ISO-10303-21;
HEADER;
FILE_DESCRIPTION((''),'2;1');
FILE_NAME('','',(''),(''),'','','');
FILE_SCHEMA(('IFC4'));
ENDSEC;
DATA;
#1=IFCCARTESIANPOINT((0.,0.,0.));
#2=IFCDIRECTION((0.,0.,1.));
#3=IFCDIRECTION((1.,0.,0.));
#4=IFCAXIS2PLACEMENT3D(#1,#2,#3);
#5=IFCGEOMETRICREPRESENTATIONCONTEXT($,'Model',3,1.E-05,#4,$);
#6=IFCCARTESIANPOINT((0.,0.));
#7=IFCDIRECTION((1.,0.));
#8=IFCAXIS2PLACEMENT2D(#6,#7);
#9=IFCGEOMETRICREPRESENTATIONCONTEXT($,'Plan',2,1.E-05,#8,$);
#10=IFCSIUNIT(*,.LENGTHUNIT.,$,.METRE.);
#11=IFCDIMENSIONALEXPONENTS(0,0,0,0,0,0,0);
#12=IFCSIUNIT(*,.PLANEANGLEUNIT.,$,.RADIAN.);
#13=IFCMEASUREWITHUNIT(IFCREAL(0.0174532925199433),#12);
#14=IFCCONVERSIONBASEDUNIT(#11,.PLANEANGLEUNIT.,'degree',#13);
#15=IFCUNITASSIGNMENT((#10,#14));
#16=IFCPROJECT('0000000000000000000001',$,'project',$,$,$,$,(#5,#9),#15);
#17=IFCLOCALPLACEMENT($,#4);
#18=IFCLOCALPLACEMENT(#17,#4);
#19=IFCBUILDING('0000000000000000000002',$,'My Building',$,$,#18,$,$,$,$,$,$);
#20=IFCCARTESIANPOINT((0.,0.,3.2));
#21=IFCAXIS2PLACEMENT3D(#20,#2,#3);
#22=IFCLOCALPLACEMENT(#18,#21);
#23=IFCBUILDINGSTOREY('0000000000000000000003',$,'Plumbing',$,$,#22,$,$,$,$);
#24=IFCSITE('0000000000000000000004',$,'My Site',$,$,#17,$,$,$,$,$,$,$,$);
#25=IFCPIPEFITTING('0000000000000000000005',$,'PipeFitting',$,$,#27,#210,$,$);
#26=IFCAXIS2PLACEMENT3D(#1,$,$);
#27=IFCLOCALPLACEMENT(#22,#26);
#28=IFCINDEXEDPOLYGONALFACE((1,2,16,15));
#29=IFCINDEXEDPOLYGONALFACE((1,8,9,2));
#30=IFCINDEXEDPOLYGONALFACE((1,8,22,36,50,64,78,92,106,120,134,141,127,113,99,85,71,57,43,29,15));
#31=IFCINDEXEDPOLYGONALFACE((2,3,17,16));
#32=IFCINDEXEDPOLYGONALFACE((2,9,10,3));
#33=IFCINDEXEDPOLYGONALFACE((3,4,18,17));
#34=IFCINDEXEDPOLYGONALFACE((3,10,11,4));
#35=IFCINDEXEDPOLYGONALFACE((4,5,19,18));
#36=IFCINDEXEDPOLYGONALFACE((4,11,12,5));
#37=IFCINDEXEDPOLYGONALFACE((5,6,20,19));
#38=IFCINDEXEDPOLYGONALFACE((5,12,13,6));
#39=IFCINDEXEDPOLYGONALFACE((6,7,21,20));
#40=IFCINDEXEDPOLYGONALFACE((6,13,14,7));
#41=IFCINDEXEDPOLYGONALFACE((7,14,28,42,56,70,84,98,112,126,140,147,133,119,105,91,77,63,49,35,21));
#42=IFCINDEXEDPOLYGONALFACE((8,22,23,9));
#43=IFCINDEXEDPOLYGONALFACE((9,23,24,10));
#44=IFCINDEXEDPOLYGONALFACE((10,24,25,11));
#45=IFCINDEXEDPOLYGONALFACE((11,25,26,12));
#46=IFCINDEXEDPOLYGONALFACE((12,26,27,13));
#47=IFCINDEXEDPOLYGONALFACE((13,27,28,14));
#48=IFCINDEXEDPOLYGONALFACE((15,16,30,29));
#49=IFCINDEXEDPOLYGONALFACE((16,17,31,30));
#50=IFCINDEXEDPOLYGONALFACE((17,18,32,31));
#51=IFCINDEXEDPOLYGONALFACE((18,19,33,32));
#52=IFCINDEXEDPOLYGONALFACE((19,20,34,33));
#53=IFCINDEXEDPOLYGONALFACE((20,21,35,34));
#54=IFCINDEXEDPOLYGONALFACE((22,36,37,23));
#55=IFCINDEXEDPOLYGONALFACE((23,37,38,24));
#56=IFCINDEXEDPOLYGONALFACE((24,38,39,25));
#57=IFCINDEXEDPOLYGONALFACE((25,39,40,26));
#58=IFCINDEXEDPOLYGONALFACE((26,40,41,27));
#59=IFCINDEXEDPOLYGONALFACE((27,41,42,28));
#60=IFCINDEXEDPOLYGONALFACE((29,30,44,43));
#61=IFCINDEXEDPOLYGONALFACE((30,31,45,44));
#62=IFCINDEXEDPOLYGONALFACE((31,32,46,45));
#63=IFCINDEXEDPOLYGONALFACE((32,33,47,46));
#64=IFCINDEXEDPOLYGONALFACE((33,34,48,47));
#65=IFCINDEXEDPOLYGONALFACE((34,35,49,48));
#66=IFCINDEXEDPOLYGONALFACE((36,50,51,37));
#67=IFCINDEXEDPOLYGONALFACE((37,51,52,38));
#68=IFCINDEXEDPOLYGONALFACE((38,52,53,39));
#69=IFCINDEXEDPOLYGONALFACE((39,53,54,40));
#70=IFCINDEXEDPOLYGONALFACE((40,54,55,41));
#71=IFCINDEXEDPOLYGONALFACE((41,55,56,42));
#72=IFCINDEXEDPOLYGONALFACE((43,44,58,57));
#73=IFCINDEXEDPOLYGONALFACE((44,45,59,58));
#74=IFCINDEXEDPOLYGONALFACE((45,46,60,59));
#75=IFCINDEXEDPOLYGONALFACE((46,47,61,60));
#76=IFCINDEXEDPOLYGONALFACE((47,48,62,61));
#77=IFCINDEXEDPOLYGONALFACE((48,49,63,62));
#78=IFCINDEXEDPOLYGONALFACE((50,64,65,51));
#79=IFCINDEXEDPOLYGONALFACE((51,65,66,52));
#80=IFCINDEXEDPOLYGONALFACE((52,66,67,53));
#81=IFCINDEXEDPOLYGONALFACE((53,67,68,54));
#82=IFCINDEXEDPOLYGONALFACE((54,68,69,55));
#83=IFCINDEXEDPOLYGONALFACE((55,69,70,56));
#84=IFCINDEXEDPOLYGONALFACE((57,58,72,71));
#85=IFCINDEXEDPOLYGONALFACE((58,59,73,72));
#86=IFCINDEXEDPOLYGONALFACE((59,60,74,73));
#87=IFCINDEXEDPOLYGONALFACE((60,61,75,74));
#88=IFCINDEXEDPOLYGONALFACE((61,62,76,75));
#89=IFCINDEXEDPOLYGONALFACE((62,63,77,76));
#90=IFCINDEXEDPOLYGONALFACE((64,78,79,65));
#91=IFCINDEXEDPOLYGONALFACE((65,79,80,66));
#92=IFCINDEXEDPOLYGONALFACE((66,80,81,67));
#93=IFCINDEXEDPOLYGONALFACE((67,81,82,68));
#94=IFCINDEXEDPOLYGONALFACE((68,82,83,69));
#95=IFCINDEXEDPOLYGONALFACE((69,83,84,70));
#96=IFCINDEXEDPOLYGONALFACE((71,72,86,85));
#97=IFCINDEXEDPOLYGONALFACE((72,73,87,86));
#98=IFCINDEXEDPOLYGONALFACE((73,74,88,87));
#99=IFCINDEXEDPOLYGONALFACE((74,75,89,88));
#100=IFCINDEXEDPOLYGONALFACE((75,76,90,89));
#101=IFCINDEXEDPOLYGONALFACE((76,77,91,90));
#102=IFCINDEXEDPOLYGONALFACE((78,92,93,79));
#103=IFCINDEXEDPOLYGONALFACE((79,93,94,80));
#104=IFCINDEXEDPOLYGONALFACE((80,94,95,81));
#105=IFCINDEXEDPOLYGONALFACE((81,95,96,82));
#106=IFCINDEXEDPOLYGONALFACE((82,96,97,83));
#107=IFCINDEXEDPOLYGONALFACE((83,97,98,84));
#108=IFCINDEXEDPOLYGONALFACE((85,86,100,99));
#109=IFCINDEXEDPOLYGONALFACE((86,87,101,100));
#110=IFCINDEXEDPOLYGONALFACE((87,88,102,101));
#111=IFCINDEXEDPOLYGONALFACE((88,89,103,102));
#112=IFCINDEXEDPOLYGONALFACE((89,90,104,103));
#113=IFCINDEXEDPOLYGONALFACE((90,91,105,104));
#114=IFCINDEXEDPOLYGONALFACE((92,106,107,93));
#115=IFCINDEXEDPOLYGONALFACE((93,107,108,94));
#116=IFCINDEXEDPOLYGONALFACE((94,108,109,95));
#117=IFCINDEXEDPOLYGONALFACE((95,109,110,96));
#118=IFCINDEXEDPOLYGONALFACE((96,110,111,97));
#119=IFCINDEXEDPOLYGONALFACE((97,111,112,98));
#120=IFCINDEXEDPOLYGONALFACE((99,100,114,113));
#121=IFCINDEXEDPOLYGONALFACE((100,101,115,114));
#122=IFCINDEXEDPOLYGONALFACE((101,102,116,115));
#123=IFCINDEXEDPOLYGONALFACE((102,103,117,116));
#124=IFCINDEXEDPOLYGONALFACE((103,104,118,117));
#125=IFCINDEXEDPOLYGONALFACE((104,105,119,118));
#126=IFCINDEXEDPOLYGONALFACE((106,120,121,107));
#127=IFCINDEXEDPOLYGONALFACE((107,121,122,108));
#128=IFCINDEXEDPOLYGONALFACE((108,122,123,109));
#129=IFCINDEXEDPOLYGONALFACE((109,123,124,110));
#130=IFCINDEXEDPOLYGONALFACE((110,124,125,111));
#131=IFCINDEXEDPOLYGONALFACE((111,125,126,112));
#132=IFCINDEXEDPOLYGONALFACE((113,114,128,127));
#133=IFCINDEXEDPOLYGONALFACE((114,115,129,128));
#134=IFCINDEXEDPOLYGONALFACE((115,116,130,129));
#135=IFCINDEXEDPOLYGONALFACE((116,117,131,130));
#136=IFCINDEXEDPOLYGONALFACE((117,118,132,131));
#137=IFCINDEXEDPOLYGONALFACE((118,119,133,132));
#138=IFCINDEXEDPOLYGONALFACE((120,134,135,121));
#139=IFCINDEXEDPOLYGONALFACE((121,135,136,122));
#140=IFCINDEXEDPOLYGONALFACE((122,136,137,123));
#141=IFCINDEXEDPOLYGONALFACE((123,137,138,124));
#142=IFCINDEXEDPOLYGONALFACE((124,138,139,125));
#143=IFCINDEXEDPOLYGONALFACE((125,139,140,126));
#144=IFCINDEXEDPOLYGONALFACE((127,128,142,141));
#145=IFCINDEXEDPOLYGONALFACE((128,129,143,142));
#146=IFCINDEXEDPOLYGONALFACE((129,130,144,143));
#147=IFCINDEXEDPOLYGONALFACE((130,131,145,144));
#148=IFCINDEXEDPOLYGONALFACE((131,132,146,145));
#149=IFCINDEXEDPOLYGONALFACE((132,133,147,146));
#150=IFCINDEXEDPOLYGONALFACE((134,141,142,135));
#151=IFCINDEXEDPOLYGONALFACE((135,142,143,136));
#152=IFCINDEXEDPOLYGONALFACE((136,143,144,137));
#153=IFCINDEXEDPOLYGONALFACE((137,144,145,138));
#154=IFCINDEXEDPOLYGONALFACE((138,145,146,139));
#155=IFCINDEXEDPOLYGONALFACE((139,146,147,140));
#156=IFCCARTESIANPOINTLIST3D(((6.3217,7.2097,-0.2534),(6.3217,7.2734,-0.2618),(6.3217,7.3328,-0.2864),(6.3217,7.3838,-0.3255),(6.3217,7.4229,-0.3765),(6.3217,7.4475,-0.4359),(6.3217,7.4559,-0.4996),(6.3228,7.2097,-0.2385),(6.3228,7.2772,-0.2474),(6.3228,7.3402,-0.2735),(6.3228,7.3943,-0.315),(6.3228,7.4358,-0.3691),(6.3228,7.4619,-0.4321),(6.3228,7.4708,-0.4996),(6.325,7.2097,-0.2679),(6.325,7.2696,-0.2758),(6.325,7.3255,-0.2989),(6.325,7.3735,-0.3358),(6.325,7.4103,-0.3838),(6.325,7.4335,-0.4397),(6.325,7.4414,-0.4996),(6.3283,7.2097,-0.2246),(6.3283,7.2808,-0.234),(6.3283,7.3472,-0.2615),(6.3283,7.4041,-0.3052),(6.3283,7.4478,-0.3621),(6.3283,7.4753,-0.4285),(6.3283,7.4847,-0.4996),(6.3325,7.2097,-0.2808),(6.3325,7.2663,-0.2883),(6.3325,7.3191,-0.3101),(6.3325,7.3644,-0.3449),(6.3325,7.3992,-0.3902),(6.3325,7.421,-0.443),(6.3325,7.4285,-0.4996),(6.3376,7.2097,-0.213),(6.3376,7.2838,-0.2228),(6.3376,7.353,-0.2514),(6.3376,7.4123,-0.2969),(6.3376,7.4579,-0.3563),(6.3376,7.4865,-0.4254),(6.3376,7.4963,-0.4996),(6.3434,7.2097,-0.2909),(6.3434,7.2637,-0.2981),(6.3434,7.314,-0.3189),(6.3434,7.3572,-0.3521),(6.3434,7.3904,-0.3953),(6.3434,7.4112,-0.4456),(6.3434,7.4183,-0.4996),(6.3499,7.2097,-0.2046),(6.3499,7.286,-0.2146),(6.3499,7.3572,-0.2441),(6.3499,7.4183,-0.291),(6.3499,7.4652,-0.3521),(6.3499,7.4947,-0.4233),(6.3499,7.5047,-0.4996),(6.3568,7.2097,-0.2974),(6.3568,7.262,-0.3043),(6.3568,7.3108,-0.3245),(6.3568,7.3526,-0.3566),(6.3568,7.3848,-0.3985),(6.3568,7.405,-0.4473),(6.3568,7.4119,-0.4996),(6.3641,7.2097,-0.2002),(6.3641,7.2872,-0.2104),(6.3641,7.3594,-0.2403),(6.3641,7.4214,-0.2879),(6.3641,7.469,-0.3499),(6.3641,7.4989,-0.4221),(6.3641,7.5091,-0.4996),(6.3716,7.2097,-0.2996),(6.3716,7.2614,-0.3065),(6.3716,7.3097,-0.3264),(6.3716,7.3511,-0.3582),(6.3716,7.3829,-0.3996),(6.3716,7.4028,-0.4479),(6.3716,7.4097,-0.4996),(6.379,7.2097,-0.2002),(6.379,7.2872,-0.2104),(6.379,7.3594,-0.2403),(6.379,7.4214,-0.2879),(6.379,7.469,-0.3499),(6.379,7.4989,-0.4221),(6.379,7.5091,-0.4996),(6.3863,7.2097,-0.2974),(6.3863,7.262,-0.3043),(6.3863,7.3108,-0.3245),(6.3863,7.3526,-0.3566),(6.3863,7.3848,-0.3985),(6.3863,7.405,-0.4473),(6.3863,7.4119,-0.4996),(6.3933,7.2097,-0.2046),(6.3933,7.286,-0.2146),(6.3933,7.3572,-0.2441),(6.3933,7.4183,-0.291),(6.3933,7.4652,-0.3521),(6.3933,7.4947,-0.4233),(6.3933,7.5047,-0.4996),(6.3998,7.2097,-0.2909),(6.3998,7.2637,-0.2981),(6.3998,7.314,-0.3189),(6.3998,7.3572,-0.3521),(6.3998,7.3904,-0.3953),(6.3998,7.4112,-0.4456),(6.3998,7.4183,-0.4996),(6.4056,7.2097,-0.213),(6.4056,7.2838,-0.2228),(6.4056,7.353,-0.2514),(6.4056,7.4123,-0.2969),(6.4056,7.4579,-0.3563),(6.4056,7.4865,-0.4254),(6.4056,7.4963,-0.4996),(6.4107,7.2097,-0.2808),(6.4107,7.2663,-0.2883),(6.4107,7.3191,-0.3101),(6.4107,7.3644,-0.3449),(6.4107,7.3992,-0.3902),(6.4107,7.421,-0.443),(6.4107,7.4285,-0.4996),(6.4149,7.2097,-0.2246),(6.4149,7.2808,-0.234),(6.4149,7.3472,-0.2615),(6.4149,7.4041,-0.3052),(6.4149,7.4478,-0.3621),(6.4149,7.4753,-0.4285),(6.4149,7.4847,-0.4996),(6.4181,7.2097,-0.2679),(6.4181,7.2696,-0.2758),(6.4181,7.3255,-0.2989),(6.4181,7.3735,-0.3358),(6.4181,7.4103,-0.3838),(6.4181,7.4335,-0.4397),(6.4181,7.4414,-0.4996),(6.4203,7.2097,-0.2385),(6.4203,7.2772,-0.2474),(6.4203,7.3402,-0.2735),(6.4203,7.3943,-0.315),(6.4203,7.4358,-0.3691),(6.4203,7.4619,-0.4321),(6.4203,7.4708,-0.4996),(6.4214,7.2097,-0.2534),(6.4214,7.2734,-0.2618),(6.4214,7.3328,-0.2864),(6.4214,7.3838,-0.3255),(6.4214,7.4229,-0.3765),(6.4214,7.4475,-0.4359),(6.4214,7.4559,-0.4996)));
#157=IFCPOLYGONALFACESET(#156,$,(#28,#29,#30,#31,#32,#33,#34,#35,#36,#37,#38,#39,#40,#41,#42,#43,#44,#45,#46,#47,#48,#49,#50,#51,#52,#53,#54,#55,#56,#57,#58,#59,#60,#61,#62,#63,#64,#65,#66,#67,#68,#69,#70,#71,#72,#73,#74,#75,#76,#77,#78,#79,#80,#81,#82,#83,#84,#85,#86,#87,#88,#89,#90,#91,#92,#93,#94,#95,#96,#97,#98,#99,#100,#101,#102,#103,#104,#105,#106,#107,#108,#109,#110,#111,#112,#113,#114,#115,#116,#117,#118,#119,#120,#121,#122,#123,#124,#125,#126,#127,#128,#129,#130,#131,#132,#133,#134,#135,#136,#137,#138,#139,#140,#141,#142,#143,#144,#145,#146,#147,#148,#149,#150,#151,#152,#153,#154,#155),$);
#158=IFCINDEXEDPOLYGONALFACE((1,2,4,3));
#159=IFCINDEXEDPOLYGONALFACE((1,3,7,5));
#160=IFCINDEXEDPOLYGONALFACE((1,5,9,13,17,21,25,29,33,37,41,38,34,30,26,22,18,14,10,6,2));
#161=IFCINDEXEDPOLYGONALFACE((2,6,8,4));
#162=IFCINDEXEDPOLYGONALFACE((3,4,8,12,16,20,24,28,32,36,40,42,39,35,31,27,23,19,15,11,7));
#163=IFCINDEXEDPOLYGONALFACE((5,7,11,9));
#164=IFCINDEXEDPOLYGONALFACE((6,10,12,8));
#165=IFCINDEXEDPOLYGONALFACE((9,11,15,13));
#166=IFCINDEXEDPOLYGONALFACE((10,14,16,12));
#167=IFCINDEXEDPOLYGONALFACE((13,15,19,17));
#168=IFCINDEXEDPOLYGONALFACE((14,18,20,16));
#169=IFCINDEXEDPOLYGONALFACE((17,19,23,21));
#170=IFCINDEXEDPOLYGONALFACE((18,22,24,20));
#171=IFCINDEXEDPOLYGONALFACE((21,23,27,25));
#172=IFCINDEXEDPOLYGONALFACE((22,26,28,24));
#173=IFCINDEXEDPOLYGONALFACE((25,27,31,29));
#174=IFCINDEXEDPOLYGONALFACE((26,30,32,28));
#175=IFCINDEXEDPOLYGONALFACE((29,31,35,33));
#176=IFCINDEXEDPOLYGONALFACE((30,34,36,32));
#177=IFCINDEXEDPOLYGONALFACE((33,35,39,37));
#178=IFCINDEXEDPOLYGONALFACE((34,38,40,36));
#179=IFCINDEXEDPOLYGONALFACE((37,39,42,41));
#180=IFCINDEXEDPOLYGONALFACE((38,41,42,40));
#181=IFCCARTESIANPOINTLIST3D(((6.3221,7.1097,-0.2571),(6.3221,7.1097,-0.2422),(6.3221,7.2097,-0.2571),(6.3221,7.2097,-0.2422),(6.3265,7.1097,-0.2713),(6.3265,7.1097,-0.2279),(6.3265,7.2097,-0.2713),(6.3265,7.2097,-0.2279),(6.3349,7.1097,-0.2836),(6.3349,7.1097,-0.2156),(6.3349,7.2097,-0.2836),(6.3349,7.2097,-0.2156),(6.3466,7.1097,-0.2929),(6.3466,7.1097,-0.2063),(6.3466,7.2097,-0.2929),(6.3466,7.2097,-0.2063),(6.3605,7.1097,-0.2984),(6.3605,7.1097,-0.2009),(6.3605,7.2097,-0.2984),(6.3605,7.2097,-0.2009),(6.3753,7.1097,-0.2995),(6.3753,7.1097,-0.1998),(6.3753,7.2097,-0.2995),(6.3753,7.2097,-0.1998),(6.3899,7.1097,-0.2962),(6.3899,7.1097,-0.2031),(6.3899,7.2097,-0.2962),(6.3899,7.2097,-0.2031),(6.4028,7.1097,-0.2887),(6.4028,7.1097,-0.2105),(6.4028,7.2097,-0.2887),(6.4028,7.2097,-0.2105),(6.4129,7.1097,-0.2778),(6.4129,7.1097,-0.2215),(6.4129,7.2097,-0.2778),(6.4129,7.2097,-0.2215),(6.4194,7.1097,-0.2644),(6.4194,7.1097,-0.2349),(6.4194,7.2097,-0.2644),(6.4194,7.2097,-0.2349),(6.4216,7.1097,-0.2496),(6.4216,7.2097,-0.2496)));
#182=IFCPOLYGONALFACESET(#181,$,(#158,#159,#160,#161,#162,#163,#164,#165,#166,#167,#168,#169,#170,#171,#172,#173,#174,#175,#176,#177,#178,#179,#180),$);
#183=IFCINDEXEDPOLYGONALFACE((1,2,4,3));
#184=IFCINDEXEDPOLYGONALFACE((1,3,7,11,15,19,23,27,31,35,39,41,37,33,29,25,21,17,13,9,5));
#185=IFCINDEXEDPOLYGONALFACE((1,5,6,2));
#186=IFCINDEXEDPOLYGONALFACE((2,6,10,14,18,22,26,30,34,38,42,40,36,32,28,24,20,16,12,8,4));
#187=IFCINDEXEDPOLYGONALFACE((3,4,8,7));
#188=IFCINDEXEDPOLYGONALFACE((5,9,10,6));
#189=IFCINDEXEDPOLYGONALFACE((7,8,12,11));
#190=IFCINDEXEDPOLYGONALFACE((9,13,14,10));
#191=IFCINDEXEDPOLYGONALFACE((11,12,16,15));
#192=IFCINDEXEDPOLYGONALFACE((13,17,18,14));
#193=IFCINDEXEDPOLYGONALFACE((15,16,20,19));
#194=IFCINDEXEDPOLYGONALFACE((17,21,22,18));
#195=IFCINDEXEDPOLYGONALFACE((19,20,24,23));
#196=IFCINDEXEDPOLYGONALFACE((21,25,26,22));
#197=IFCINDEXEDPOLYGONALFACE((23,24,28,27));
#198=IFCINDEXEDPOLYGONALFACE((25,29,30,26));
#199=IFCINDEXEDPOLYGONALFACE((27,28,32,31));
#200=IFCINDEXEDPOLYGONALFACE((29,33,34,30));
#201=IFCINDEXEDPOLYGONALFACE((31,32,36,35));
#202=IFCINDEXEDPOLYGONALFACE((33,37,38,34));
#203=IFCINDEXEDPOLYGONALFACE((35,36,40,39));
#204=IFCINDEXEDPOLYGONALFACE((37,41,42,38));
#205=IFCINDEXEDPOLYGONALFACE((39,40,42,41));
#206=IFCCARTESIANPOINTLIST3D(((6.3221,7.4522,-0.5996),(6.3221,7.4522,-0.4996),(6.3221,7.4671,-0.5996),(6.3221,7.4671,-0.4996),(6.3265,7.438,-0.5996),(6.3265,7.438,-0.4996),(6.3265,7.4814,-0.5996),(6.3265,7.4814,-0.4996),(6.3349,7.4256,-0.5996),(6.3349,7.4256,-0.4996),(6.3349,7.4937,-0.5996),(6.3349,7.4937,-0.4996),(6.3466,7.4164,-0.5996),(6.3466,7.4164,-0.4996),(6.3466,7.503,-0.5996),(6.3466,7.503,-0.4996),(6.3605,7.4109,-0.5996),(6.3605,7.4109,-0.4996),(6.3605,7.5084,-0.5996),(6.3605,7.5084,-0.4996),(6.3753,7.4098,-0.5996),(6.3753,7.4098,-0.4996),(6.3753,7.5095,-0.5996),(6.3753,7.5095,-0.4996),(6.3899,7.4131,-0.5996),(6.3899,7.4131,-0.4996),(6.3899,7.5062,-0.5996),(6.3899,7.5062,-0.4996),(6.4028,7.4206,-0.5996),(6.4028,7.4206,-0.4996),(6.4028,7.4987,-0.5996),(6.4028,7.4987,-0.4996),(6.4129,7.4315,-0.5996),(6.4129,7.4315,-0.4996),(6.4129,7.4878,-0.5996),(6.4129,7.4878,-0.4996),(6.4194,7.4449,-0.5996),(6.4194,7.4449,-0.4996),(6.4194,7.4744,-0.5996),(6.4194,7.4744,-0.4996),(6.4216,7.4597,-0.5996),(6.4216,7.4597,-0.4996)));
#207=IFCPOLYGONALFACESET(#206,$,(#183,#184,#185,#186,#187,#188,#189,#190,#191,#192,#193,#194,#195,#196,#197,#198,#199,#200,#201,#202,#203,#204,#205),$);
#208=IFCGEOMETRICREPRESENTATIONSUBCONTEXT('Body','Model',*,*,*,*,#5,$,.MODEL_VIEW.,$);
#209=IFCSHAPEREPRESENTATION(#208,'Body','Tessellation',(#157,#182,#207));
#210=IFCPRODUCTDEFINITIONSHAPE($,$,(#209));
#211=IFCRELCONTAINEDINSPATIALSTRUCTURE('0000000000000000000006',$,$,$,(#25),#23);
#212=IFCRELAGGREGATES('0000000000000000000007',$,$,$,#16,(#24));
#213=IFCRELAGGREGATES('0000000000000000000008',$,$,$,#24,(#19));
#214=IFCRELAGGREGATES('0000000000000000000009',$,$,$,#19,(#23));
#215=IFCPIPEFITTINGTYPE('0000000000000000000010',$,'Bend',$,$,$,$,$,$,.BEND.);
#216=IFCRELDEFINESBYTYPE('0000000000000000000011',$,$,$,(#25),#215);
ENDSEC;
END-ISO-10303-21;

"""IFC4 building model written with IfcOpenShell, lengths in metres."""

from ifc_helpers import new_model, entity, si_unit, converted_unit, frame, origin_with_axes, origin_2d_with_axis, place, context, subcontext, project, spatial, circle, extrude, source, transform, mapped, type_object, type_shapes, element, save


model = new_model("IFC4")

# Units and contexts
model_context = context("Model", 3, precision=1e-05, world=origin_with_axes())
plan_context = context("Plan", 2, precision=1e-05, world=origin_2d_with_axis())
body_context = subcontext(model_context, "Body", "Model", "MODEL_VIEW")
ifc_project = project(units=[si_unit("LENGTHUNIT", "METRE"), converted_unit("PLANEANGLEUNIT", "degree", entity("IfcReal", 0.0174532925199433), si_unit("PLANEANGLEUNIT", "RADIAN"), dimensions=[0, 0, 0, 0, 0, 0, 0])], contexts=[model_context, plan_context])

# Site, building, storey
site_placement = place(None, origin_with_axes())
site = spatial("IfcSite", under=ifc_project, at=site_placement, Name="My Site")
building_placement = place(site_placement, origin_with_axes())
building = spatial("IfcBuilding", under=site, at=building_placement, Name="My Building")
storey_placement = place(building_placement, frame((0.0, 0.0, 3.2), z_axis=(0.0, 0.0, 1.0), x_axis=(1.0, 0.0, 0.0)))
storey = spatial("IfcBuildingStorey", under=building, at=storey_placement, Name="Plumbing")

# Pipe fitting
pipe_fitting_type = type_object("IfcPipeFittingType", Name="Bend", PredefinedType="BEND")
shared_shape = source(origin_with_axes(), body_context, "Body", "SolidModel", [
    entity("IfcSweptDiskSolid", entity("IfcIndexedPolyCurve", entity("IfcCartesianPointList3D", [[0.0, 0.0, -0.1], [0.0, -0.0732, -0.2768], [0.0, -0.25, -0.35]]), [entity("IfcArcIndex", [1, 2, 3])]), 0.05),
    extrude(circle(Radius=0.05), origin_with_axes(), (0.0, 0.0, -1.0), 0.1),
    extrude(circle(Radius=0.05), frame((0.0, -0.25, -0.35), z_axis=(0.0, -1.0, 0.0), x_axis=(1.0, 0.0, 0.0)), (0.0, 0.0, 1.0), 0.1),
])
type_shapes(pipe_fitting_type, [shared_shape])
for number, where, z_axis, x_axis, name in (
    (1, (6.3716, 7.1097, -0.2496), (0.0, -1.0, 0.0), (1.0, 0.0, 0.0), "PipeFitting"),
):
    element("IfcPipeFitting", number, at=place(storey_placement, frame(where, z_axis=z_axis, x_axis=x_axis)), inside=storey, type_object=pipe_fitting_type, Name=name, context=body_context, shape_type="MappedRepresentation", body=[
        mapped(shared_shape, transform((0.0, 0.0, 0.0), x_axis=(1.0, 0.0, 0.0), y_axis=(0.0, 1.0, 0.0), z_axis=(0.0, 0.0, 1.0), scale=1.0)),
    ])

save(model, "model.ifc")
